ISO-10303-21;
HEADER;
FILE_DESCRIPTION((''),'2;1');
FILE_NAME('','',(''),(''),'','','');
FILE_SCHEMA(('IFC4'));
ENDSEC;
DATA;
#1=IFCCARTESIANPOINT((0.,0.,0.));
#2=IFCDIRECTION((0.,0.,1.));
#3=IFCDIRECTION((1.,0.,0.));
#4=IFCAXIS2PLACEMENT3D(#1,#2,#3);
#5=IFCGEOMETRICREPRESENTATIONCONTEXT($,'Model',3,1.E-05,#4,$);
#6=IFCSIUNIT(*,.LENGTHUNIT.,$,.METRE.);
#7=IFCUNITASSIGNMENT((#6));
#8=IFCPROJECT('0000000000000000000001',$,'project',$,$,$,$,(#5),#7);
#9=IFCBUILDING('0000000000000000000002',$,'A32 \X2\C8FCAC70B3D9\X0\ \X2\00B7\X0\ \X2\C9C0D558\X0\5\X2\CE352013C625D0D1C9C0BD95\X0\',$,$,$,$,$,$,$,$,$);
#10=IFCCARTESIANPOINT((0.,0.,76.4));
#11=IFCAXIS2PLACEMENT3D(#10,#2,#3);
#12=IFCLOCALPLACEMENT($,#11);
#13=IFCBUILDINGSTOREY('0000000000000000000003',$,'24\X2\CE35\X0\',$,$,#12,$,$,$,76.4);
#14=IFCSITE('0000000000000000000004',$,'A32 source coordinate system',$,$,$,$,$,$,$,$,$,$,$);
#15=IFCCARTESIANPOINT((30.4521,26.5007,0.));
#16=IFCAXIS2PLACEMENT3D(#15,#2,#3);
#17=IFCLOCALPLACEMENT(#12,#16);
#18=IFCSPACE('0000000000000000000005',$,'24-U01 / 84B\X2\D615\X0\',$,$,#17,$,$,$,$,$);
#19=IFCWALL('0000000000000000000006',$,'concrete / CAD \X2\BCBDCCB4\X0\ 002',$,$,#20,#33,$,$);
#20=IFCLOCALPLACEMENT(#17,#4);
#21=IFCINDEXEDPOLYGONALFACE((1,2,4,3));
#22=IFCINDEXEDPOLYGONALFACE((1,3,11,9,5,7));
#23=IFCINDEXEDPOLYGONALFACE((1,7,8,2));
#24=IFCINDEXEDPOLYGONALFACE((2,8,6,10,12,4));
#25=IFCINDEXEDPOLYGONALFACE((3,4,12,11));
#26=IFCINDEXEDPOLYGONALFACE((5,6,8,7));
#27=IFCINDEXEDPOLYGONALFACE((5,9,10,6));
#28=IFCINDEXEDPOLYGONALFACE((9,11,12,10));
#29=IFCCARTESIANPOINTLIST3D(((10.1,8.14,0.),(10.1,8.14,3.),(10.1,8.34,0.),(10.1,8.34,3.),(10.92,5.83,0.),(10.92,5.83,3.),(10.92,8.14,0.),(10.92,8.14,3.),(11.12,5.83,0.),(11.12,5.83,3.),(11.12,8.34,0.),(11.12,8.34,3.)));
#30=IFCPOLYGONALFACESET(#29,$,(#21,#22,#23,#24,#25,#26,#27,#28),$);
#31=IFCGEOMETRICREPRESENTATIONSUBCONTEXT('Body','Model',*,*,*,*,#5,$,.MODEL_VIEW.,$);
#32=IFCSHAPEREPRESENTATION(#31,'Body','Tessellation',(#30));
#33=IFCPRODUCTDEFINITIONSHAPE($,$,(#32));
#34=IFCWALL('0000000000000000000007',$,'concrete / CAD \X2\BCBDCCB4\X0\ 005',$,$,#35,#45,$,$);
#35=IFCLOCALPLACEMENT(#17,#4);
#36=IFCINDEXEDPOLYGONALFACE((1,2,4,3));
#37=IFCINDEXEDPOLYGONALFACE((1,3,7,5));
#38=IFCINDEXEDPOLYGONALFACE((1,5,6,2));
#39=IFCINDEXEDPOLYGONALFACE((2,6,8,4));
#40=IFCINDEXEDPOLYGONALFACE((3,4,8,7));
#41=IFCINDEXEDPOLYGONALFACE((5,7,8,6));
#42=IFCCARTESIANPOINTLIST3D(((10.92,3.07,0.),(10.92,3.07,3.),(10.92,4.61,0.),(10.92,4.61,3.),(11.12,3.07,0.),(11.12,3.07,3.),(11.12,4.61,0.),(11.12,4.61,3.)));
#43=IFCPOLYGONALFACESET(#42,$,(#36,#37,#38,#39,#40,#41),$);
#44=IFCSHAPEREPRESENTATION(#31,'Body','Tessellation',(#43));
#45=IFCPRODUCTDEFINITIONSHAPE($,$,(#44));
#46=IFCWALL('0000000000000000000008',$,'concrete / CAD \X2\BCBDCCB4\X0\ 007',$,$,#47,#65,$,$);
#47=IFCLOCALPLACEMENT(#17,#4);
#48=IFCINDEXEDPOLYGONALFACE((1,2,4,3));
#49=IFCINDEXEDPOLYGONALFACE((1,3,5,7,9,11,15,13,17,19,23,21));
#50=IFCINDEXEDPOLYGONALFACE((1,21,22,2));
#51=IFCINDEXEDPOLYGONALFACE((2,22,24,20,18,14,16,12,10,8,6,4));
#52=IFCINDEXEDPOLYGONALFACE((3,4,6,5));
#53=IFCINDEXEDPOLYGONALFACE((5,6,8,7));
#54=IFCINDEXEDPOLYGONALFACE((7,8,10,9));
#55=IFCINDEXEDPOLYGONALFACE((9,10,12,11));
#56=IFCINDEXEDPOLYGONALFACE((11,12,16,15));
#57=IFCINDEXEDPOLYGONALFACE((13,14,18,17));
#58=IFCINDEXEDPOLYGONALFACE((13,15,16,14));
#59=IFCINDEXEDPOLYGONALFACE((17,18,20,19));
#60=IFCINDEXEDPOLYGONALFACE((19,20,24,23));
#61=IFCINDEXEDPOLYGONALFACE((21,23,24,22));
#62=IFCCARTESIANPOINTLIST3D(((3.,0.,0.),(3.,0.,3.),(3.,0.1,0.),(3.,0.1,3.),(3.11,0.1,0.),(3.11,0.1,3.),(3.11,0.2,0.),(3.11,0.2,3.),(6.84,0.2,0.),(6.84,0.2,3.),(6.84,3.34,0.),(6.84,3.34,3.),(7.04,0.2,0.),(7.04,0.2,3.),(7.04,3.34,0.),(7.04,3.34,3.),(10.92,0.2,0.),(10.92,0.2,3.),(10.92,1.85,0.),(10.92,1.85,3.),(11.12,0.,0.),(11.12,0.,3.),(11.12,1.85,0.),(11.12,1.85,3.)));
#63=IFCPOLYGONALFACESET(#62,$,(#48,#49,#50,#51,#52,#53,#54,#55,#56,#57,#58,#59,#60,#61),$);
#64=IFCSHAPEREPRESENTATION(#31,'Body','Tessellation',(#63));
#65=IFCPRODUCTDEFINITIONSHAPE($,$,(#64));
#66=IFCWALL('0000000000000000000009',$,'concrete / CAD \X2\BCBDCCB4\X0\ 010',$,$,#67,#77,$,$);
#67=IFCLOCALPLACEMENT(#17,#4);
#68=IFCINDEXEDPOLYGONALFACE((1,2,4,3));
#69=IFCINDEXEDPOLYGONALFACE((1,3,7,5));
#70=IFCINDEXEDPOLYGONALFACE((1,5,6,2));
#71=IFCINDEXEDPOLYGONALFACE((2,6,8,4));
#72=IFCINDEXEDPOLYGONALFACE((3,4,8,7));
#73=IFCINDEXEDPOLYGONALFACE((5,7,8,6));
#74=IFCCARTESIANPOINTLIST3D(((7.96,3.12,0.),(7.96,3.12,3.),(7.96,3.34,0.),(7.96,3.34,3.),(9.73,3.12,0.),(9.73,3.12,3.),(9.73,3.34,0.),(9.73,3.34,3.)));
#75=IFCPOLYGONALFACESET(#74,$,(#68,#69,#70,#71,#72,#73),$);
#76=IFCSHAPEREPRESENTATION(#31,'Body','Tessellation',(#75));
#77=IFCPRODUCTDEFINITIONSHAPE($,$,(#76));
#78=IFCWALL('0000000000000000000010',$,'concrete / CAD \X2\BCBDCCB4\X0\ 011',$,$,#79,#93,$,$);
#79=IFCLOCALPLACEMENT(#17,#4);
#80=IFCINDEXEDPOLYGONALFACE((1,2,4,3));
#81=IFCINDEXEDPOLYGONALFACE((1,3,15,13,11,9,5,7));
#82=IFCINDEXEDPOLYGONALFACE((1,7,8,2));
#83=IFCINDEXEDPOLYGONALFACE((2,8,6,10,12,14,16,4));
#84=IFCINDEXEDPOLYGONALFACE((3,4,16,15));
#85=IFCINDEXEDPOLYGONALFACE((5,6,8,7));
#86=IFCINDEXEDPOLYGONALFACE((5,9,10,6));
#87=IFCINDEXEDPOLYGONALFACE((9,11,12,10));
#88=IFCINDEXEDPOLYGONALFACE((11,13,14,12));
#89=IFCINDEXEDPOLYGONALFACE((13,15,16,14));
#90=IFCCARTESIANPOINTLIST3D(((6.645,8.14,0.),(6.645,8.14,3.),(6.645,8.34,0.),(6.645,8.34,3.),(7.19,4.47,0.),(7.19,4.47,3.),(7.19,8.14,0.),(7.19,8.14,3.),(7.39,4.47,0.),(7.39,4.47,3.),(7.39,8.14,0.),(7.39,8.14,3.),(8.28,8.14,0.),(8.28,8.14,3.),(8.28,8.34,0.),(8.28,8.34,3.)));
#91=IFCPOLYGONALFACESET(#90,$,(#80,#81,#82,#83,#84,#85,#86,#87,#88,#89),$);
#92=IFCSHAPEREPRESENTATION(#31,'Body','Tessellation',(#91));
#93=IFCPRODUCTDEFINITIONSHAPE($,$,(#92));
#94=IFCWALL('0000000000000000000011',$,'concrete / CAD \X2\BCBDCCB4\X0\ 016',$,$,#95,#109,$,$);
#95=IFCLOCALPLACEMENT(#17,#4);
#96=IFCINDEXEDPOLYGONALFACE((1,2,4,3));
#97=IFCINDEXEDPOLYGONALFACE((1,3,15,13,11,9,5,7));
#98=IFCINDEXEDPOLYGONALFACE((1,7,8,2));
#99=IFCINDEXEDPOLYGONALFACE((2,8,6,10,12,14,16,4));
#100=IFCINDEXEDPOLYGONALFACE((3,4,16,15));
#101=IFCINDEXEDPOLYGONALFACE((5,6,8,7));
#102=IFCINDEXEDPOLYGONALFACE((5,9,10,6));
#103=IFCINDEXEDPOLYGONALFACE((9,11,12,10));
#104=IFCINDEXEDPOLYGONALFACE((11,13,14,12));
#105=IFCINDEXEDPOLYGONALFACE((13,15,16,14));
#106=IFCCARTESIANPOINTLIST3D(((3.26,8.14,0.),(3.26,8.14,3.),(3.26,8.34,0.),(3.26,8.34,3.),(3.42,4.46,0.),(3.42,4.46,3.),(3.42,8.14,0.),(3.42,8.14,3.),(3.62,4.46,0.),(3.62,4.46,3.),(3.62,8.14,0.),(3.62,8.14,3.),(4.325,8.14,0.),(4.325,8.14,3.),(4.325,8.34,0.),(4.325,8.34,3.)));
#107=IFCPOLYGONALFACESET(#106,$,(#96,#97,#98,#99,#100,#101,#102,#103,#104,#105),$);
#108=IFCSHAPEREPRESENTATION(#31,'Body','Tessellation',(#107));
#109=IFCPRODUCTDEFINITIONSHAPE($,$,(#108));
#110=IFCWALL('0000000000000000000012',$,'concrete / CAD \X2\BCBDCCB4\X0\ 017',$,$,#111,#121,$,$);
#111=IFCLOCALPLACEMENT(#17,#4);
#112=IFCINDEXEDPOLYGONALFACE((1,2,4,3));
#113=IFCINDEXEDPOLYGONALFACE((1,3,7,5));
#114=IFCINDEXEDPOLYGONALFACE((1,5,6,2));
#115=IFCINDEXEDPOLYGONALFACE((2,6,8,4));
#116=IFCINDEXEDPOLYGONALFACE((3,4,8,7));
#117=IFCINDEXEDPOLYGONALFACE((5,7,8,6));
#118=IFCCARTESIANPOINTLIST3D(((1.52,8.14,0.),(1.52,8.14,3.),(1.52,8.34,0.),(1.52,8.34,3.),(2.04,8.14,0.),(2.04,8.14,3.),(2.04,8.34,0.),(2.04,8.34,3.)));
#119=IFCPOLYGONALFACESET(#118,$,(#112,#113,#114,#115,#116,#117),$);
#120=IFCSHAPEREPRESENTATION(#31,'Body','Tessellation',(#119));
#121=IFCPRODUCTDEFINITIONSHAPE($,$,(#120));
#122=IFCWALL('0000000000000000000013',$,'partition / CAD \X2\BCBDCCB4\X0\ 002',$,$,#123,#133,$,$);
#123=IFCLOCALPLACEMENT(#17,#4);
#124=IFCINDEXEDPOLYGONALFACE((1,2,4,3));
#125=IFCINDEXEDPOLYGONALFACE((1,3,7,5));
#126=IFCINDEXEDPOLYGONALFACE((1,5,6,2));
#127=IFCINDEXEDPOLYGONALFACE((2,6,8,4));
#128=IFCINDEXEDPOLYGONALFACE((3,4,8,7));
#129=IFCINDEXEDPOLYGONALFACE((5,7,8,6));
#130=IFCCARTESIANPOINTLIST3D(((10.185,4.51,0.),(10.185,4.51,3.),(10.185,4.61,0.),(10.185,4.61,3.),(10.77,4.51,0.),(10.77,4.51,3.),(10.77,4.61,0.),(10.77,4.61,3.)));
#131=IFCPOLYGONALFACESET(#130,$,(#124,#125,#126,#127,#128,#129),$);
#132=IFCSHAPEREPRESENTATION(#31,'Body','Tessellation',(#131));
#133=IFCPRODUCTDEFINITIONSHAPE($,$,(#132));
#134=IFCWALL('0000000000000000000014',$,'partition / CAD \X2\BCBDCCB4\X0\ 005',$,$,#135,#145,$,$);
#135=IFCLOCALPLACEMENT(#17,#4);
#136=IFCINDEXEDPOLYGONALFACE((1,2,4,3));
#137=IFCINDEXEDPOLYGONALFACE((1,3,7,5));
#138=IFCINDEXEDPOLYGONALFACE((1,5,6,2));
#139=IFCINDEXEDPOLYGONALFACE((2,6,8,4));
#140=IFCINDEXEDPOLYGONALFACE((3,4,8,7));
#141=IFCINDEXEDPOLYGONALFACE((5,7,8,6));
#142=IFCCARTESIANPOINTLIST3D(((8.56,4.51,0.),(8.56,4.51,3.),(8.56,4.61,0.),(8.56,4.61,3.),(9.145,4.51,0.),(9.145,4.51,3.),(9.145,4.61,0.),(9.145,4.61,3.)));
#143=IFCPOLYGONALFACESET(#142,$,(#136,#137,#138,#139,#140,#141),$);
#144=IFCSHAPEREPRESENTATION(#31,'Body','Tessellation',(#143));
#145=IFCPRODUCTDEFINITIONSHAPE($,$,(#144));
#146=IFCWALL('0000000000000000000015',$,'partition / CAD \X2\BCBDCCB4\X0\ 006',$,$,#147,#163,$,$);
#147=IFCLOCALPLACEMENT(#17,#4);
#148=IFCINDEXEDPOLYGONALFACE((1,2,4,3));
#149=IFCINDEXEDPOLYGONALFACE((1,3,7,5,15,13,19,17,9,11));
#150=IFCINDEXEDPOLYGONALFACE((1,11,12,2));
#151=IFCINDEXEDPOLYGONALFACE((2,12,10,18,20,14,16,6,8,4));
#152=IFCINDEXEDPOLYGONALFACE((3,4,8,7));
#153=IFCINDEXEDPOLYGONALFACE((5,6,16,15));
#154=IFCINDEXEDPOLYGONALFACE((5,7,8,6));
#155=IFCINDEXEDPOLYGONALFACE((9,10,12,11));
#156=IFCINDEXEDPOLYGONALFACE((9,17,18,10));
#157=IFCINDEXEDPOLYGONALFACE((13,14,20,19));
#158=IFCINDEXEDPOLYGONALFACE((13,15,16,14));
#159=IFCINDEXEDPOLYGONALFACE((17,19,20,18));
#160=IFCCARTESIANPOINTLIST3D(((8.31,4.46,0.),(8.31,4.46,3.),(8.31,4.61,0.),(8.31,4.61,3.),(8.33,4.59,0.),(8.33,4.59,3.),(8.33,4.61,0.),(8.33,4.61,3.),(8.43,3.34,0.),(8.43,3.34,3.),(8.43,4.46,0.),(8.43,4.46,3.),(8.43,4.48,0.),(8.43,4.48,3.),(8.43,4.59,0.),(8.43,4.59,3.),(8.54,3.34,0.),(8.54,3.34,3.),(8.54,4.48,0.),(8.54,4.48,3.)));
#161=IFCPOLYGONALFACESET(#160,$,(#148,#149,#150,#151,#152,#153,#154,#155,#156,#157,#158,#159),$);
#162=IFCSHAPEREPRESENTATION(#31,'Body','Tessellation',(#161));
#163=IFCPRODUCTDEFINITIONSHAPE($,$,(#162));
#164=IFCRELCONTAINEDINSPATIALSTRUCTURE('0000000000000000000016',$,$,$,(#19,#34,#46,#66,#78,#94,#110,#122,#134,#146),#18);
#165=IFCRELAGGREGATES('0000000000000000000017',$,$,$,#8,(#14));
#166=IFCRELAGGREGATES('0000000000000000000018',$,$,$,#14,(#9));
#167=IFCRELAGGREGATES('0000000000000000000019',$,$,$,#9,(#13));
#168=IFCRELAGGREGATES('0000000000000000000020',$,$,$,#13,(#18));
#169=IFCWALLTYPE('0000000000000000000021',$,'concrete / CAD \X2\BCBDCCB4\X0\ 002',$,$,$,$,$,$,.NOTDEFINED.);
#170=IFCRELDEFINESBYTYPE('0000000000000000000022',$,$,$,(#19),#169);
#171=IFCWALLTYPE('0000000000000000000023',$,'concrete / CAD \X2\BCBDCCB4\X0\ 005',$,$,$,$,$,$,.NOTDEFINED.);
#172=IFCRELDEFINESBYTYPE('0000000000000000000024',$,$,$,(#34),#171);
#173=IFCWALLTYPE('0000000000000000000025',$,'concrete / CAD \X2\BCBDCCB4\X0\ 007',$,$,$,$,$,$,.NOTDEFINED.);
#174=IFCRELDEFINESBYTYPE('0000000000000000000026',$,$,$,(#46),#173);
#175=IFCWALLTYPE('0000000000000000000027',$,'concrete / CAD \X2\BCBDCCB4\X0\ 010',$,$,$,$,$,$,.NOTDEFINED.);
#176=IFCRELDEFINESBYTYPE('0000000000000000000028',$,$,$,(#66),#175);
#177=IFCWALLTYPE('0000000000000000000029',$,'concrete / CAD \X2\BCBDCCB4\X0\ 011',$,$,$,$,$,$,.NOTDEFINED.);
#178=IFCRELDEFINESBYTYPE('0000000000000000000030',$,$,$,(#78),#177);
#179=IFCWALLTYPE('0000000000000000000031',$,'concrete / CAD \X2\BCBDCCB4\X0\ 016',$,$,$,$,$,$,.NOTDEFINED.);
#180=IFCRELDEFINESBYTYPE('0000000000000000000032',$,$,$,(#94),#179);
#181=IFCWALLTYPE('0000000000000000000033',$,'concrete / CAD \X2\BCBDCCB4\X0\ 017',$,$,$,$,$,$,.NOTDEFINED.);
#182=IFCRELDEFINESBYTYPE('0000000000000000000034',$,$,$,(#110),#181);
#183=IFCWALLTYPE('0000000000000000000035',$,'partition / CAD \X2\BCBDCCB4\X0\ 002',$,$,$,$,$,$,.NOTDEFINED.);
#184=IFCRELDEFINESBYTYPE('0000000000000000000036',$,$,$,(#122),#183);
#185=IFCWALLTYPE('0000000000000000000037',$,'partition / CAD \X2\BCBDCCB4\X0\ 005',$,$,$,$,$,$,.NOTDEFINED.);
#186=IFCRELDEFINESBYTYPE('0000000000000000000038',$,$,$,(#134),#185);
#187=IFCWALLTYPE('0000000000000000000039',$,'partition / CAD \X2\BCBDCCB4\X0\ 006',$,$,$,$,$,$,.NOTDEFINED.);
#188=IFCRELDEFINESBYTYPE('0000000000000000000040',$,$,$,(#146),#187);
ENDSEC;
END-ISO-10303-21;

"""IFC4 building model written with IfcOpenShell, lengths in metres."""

from ifc_helpers import new_model, si_unit, frame, origin, origin_with_axes, place, context, subcontext, project, spatial, polyline, outline, extrude, source, transform, mapped, type_object, type_shapes, element, save


model = new_model("IFC4")

# Units and contexts
model_context = context("Model", 3, precision=1e-05, world=origin_with_axes())
body_context = subcontext(model_context, "Body", "Model", "MODEL_VIEW")
ifc_project = project(units=[si_unit("LENGTHUNIT", "METRE")], contexts=[model_context])

# Site, building, storey, space
site = spatial("IfcSite", under=ifc_project, Name="A32 source coordinate system")
building = spatial("IfcBuilding", under=site, Name="A32 주거동 · 지하5층–옥탑지붕")
storey_placement = place(None, frame((0.0, 0.0, 76.4), z_axis=(0.0, 0.0, 1.0), x_axis=(1.0, 0.0, 0.0)))
storey = spatial("IfcBuildingStorey", under=building, at=storey_placement, Name="24층", Elevation=76.4)
space_placement = place(storey_placement, frame((30.4521, 26.5007, 0.0), z_axis=(0.0, 0.0, 1.0), x_axis=(1.0, 0.0, 0.0)))
space = spatial("IfcSpace", under=storey, at=space_placement, Name="24-U01 / 84B형")

# Walls
wall_type_1 = type_object("IfcWallType", Name="concrete / CAD 벽체 002", PredefinedType="NOTDEFINED")
shared_shape_1 = source(origin(), body_context, "Body", "SweptSolid", [
    extrude(outline(polyline([(11.12, 5.83), (10.92, 5.83), (10.92, 8.14), (10.1, 8.14), (10.1, 8.34), (11.12, 8.34), (11.12, 5.83)])), origin(), (0.0, 0.0, 1.0), 3.0),
])
type_shapes(wall_type_1, [shared_shape_1])
wall_1_placement = place(space_placement, origin_with_axes())
element("IfcWall", 1, at=wall_1_placement, inside=space, type_object=wall_type_1, Name="concrete / CAD 벽체 002", context=body_context, shape_type="MappedRepresentation", body=[
    mapped(shared_shape_1, transform((0.0, 0.0, 0.0), scale=1.0)),
])
wall_type_2 = type_object("IfcWallType", Name="concrete / CAD 벽체 005", PredefinedType="NOTDEFINED")
shared_shape_2 = source(origin(), body_context, "Body", "SweptSolid", [
    extrude(outline(polyline([(11.12, 3.07), (10.92, 3.07), (10.92, 4.61), (11.12, 4.61), (11.12, 3.07)])), origin(), (0.0, 0.0, 1.0), 3.0),
])
type_shapes(wall_type_2, [shared_shape_2])
wall_2_placement = place(space_placement, origin_with_axes())
element("IfcWall", 2, at=wall_2_placement, inside=space, type_object=wall_type_2, Name="concrete / CAD 벽체 005", context=body_context, shape_type="MappedRepresentation", body=[
    mapped(shared_shape_2, transform((0.0, 0.0, 0.0), scale=1.0)),
])
wall_type_3 = type_object("IfcWallType", Name="concrete / CAD 벽체 007", PredefinedType="NOTDEFINED")
shared_shape_3 = source(origin(), body_context, "Body", "SweptSolid", [
    extrude(outline(polyline([(3.0, 0.0), (3.0, 0.1), (3.11, 0.1), (3.11, 0.2), (6.84, 0.2), (6.84, 3.34), (7.04, 3.34), (7.04, 0.2), (10.92, 0.2), (10.92, 1.85), (11.12, 1.85), (11.12, 0.0), (3.0, 0.0)])), origin(), (0.0, 0.0, 1.0), 3.0),
])
type_shapes(wall_type_3, [shared_shape_3])
wall_3_placement = place(space_placement, origin_with_axes())
element("IfcWall", 3, at=wall_3_placement, inside=space, type_object=wall_type_3, Name="concrete / CAD 벽체 007", context=body_context, shape_type="MappedRepresentation", body=[
    mapped(shared_shape_3, transform((0.0, 0.0, 0.0), scale=1.0)),
])
wall_type_4 = type_object("IfcWallType", Name="concrete / CAD 벽체 010", PredefinedType="NOTDEFINED")
shared_shape_4 = source(origin(), body_context, "Body", "SweptSolid", [
    extrude(outline(polyline([(7.96, 3.12), (7.96, 3.34), (9.73, 3.34), (9.73, 3.12), (7.96, 3.12)])), origin(), (0.0, 0.0, 1.0), 3.0),
])
type_shapes(wall_type_4, [shared_shape_4])
wall_4_placement = place(space_placement, origin_with_axes())
element("IfcWall", 4, at=wall_4_placement, inside=space, type_object=wall_type_4, Name="concrete / CAD 벽체 010", context=body_context, shape_type="MappedRepresentation", body=[
    mapped(shared_shape_4, transform((0.0, 0.0, 0.0), scale=1.0)),
])
wall_type_5 = type_object("IfcWallType", Name="concrete / CAD 벽체 011", PredefinedType="NOTDEFINED")
shared_shape_5 = source(origin(), body_context, "Body", "SweptSolid", [
    extrude(outline(polyline([(7.19, 8.14), (6.645, 8.14), (6.645, 8.34), (8.28, 8.34), (8.28, 8.14), (7.39, 8.14), (7.39, 4.47), (7.19, 4.47), (7.19, 8.14)])), origin(), (0.0, 0.0, 1.0), 3.0),
])
type_shapes(wall_type_5, [shared_shape_5])
wall_5_placement = place(space_placement, origin_with_axes())
element("IfcWall", 5, at=wall_5_placement, inside=space, type_object=wall_type_5, Name="concrete / CAD 벽체 011", context=body_context, shape_type="MappedRepresentation", body=[
    mapped(shared_shape_5, transform((0.0, 0.0, 0.0), scale=1.0)),
])
wall_type_6 = type_object("IfcWallType", Name="concrete / CAD 벽체 016", PredefinedType="NOTDEFINED")
shared_shape_6 = source(origin(), body_context, "Body", "SweptSolid", [
    extrude(outline(polyline([(3.26, 8.14), (3.26, 8.34), (4.325, 8.34), (4.325, 8.14), (3.62, 8.14), (3.62, 4.46), (3.42, 4.46), (3.42, 8.14), (3.26, 8.14)])), origin(), (0.0, 0.0, 1.0), 3.0),
])
type_shapes(wall_type_6, [shared_shape_6])
wall_6_placement = place(space_placement, origin_with_axes())
element("IfcWall", 6, at=wall_6_placement, inside=space, type_object=wall_type_6, Name="concrete / CAD 벽체 016", context=body_context, shape_type="MappedRepresentation", body=[
    mapped(shared_shape_6, transform((0.0, 0.0, 0.0), scale=1.0)),
])
wall_type_7 = type_object("IfcWallType", Name="concrete / CAD 벽체 017", PredefinedType="NOTDEFINED")
shared_shape_7 = source(origin(), body_context, "Body", "SweptSolid", [
    extrude(outline(polyline([(1.52, 8.34), (2.04, 8.34), (2.04, 8.14), (1.52, 8.14), (1.52, 8.34)])), origin(), (0.0, 0.0, 1.0), 3.0),
])
type_shapes(wall_type_7, [shared_shape_7])
wall_7_placement = place(space_placement, origin_with_axes())
element("IfcWall", 7, at=wall_7_placement, inside=space, type_object=wall_type_7, Name="concrete / CAD 벽체 017", context=body_context, shape_type="MappedRepresentation", body=[
    mapped(shared_shape_7, transform((0.0, 0.0, 0.0), scale=1.0)),
])
wall_type_8 = type_object("IfcWallType", Name="partition / CAD 벽체 002", PredefinedType="NOTDEFINED")
shared_shape_8 = source(origin(), body_context, "Body", "SweptSolid", [
    extrude(outline(polyline([(10.185, 4.51), (10.185, 4.61), (10.77, 4.61), (10.77, 4.51), (10.185, 4.51)])), origin(), (0.0, 0.0, 1.0), 3.0),
])
type_shapes(wall_type_8, [shared_shape_8])
wall_8_placement = place(space_placement, origin_with_axes())
element("IfcWall", 8, at=wall_8_placement, inside=space, type_object=wall_type_8, Name="partition / CAD 벽체 002", context=body_context, shape_type="MappedRepresentation", body=[
    mapped(shared_shape_8, transform((0.0, 0.0, 0.0), scale=1.0)),
])
wall_type_9 = type_object("IfcWallType", Name="partition / CAD 벽체 005", PredefinedType="NOTDEFINED")
shared_shape_9 = source(origin(), body_context, "Body", "SweptSolid", [
    extrude(outline(polyline([(8.56, 4.51), (8.56, 4.61), (9.145, 4.61), (9.145, 4.51), (8.56, 4.51)])), origin(), (0.0, 0.0, 1.0), 3.0),
])
type_shapes(wall_type_9, [shared_shape_9])
wall_9_placement = place(space_placement, origin_with_axes())
element("IfcWall", 9, at=wall_9_placement, inside=space, type_object=wall_type_9, Name="partition / CAD 벽체 005", context=body_context, shape_type="MappedRepresentation", body=[
    mapped(shared_shape_9, transform((0.0, 0.0, 0.0), scale=1.0)),
])
wall_type_10 = type_object("IfcWallType", Name="partition / CAD 벽체 006", PredefinedType="NOTDEFINED")
shared_shape_10 = source(origin(), body_context, "Body", "SweptSolid", [
    extrude(outline(polyline([(8.43, 4.46), (8.31, 4.46), (8.31, 4.61), (8.33, 4.61), (8.33, 4.59), (8.43, 4.59), (8.43, 4.48), (8.54, 4.48), (8.54, 3.34), (8.43, 3.34), (8.43, 4.46)])), origin(), (0.0, 0.0, 1.0), 3.0),
])
type_shapes(wall_type_10, [shared_shape_10])
wall_10_placement = place(space_placement, origin_with_axes())
element("IfcWall", 10, at=wall_10_placement, inside=space, type_object=wall_type_10, Name="partition / CAD 벽체 006", context=body_context, shape_type="MappedRepresentation", body=[
    mapped(shared_shape_10, transform((0.0, 0.0, 0.0), scale=1.0)),
])

save(model, "model.ifc")
